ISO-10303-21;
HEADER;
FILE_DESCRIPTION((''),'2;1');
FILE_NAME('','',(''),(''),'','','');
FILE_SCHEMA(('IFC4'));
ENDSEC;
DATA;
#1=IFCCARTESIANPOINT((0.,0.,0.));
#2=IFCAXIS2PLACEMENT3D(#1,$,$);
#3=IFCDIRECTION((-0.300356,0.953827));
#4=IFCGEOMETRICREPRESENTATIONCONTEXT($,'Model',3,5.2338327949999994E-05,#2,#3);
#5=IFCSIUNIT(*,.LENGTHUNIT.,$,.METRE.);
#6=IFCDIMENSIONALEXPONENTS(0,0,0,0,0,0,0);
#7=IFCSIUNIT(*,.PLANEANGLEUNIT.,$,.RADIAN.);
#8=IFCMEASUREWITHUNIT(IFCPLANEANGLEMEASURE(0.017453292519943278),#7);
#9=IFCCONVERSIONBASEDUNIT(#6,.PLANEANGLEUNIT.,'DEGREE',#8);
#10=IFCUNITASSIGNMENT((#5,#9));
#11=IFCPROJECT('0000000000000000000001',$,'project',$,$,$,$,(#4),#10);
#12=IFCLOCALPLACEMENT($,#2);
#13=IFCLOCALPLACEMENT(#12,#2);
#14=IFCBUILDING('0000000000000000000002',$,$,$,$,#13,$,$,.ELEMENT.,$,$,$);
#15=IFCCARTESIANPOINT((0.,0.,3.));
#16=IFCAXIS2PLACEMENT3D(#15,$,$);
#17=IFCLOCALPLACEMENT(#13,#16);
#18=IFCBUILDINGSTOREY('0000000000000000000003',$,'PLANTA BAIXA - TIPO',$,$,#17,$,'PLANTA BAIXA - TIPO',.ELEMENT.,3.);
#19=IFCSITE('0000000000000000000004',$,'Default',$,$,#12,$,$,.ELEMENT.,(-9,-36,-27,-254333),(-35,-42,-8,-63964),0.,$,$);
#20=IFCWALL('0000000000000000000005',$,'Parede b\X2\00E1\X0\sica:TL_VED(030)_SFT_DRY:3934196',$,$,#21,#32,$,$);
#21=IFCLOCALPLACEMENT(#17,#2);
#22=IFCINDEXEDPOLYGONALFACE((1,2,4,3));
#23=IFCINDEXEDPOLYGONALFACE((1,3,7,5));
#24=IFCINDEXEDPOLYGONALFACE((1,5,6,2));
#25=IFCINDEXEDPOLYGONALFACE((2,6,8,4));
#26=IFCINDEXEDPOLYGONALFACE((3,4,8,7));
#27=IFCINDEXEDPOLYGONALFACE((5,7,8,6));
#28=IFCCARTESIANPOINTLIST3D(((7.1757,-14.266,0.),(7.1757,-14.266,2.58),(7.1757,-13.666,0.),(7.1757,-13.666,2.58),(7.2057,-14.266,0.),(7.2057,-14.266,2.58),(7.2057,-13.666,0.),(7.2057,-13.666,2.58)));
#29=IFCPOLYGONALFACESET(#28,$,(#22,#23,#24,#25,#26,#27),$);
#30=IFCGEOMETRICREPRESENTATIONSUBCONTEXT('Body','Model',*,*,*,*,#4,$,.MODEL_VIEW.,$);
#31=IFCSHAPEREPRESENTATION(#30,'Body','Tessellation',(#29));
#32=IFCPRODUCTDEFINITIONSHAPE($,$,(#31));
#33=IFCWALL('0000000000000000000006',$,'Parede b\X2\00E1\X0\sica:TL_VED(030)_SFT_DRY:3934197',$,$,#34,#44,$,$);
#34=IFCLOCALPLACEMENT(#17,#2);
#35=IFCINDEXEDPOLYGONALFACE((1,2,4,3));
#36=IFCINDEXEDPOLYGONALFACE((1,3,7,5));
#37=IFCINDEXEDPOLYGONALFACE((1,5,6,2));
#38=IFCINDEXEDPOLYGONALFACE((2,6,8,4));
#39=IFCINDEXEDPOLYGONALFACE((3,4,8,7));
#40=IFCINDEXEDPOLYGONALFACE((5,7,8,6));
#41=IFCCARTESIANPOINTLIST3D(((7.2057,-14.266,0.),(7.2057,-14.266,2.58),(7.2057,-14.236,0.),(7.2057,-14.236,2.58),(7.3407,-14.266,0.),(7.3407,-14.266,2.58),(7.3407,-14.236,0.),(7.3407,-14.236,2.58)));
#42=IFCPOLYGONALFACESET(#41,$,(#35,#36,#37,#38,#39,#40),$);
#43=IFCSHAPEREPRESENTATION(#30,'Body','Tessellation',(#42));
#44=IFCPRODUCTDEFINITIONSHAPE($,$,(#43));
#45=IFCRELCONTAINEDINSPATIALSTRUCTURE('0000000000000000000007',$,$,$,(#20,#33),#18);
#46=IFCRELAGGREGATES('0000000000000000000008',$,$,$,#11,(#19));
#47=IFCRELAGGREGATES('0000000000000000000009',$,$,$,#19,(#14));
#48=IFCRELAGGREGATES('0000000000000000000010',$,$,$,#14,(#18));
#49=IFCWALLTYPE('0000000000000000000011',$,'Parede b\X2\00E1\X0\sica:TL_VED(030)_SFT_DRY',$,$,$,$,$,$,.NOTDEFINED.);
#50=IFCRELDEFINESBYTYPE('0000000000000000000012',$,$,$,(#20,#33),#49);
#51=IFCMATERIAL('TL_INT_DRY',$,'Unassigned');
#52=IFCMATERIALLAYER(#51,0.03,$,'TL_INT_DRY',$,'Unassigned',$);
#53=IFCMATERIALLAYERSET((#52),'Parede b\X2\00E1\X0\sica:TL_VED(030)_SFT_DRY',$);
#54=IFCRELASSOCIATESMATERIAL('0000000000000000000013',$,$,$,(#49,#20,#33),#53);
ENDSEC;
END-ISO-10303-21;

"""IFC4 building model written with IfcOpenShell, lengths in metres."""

from ifc_helpers import new_model, entity, si_unit, converted_unit, direction, frame, frame_2d, origin, place, context, subcontext, project, spatial, rectangle, extrude, material, layer, layer_set, layer_usage, type_object, element, save


model = new_model("IFC4")

# Units and contexts
model_context = context("Model", 3, precision=5.2338327949999994e-05, world=origin(), true_north=direction((-0.300356, 0.953827)))
body_context = subcontext(model_context, "Body", "Model", "MODEL_VIEW")
ifc_project = project(units=[si_unit("LENGTHUNIT", "METRE"), converted_unit("PLANEANGLEUNIT", "DEGREE", entity("IfcPlaneAngleMeasure", 0.017453292519943278), si_unit("PLANEANGLEUNIT", "RADIAN"), dimensions=[0, 0, 0, 0, 0, 0, 0])], contexts=[model_context])

# Site, building, storey
site_placement = place(None, origin())
site = spatial("IfcSite", under=ifc_project, at=site_placement, Name="Default", CompositionType="ELEMENT", RefLatitude=(-9, -36, -27, -254333), RefLongitude=(-35, -42, -8, -63964), RefElevation=0.0)
building_placement = place(site_placement, origin())
building = spatial("IfcBuilding", under=site, at=building_placement, CompositionType="ELEMENT")
storey_placement = place(building_placement, frame((0.0, 0.0, 3.0)))
storey = spatial("IfcBuildingStorey", under=building, at=storey_placement, Name="PLANTA BAIXA - TIPO", LongName="PLANTA BAIXA - TIPO", CompositionType="ELEMENT", Elevation=3.0)

# Walls
ifc_material_1 = material(Name="TL_INT_DRY", Category="Unassigned")
ifc_layer_1 = layer(ifc_material_1, 0.03, Name="TL_INT_DRY", Category="Unassigned")
ifc_layer_set_1 = layer_set([ifc_layer_1], Name="Parede básica:TL_VED(030)_SFT_DRY")
ifc_layer_usage_1 = layer_usage(ifc_layer_set_1, "AXIS2", "POSITIVE", -0.015)
wall_type_1 = type_object("IfcWallType", Name="Parede básica:TL_VED(030)_SFT_DRY", PredefinedType="NOTDEFINED", material=ifc_layer_set_1)
wall_1_placement = place(storey_placement, frame((7.1907, -13.666, 0.0), z_axis=(0.0, 0.0, 1.0), x_axis=(0.0, -1.0, 0.0)))
element("IfcWall", 1, at=wall_1_placement, inside=storey, type_object=wall_type_1, material=ifc_layer_usage_1, Name="Parede básica:TL_VED(030)_SFT_DRY:3934196", context=body_context, shape_type="SweptSolid", body=[
    extrude(rectangle(XDim=0.6, YDim=0.03, at=frame_2d((0.3, 0.0), x_axis=(-1.0, 0.0))), origin(), (0.0, 0.0, 1.0), 2.58),
])
ifc_layer_usage_2 = layer_usage(ifc_layer_set_1, "AXIS2", "POSITIVE", -0.015)
wall_2_placement = place(storey_placement, frame((7.2057, -14.251, 0.0)))
element("IfcWall", 2, at=wall_2_placement, inside=storey, type_object=wall_type_1, material=ifc_layer_usage_2, Name="Parede básica:TL_VED(030)_SFT_DRY:3934197", context=body_context, shape_type="SweptSolid", body=[
    extrude(rectangle(XDim=0.135, YDim=0.03, at=frame_2d((0.0675, 0.0), x_axis=(-1.0, 0.0))), origin(), (0.0, 0.0, 1.0), 2.58),
])

save(model, "model.ifc")
